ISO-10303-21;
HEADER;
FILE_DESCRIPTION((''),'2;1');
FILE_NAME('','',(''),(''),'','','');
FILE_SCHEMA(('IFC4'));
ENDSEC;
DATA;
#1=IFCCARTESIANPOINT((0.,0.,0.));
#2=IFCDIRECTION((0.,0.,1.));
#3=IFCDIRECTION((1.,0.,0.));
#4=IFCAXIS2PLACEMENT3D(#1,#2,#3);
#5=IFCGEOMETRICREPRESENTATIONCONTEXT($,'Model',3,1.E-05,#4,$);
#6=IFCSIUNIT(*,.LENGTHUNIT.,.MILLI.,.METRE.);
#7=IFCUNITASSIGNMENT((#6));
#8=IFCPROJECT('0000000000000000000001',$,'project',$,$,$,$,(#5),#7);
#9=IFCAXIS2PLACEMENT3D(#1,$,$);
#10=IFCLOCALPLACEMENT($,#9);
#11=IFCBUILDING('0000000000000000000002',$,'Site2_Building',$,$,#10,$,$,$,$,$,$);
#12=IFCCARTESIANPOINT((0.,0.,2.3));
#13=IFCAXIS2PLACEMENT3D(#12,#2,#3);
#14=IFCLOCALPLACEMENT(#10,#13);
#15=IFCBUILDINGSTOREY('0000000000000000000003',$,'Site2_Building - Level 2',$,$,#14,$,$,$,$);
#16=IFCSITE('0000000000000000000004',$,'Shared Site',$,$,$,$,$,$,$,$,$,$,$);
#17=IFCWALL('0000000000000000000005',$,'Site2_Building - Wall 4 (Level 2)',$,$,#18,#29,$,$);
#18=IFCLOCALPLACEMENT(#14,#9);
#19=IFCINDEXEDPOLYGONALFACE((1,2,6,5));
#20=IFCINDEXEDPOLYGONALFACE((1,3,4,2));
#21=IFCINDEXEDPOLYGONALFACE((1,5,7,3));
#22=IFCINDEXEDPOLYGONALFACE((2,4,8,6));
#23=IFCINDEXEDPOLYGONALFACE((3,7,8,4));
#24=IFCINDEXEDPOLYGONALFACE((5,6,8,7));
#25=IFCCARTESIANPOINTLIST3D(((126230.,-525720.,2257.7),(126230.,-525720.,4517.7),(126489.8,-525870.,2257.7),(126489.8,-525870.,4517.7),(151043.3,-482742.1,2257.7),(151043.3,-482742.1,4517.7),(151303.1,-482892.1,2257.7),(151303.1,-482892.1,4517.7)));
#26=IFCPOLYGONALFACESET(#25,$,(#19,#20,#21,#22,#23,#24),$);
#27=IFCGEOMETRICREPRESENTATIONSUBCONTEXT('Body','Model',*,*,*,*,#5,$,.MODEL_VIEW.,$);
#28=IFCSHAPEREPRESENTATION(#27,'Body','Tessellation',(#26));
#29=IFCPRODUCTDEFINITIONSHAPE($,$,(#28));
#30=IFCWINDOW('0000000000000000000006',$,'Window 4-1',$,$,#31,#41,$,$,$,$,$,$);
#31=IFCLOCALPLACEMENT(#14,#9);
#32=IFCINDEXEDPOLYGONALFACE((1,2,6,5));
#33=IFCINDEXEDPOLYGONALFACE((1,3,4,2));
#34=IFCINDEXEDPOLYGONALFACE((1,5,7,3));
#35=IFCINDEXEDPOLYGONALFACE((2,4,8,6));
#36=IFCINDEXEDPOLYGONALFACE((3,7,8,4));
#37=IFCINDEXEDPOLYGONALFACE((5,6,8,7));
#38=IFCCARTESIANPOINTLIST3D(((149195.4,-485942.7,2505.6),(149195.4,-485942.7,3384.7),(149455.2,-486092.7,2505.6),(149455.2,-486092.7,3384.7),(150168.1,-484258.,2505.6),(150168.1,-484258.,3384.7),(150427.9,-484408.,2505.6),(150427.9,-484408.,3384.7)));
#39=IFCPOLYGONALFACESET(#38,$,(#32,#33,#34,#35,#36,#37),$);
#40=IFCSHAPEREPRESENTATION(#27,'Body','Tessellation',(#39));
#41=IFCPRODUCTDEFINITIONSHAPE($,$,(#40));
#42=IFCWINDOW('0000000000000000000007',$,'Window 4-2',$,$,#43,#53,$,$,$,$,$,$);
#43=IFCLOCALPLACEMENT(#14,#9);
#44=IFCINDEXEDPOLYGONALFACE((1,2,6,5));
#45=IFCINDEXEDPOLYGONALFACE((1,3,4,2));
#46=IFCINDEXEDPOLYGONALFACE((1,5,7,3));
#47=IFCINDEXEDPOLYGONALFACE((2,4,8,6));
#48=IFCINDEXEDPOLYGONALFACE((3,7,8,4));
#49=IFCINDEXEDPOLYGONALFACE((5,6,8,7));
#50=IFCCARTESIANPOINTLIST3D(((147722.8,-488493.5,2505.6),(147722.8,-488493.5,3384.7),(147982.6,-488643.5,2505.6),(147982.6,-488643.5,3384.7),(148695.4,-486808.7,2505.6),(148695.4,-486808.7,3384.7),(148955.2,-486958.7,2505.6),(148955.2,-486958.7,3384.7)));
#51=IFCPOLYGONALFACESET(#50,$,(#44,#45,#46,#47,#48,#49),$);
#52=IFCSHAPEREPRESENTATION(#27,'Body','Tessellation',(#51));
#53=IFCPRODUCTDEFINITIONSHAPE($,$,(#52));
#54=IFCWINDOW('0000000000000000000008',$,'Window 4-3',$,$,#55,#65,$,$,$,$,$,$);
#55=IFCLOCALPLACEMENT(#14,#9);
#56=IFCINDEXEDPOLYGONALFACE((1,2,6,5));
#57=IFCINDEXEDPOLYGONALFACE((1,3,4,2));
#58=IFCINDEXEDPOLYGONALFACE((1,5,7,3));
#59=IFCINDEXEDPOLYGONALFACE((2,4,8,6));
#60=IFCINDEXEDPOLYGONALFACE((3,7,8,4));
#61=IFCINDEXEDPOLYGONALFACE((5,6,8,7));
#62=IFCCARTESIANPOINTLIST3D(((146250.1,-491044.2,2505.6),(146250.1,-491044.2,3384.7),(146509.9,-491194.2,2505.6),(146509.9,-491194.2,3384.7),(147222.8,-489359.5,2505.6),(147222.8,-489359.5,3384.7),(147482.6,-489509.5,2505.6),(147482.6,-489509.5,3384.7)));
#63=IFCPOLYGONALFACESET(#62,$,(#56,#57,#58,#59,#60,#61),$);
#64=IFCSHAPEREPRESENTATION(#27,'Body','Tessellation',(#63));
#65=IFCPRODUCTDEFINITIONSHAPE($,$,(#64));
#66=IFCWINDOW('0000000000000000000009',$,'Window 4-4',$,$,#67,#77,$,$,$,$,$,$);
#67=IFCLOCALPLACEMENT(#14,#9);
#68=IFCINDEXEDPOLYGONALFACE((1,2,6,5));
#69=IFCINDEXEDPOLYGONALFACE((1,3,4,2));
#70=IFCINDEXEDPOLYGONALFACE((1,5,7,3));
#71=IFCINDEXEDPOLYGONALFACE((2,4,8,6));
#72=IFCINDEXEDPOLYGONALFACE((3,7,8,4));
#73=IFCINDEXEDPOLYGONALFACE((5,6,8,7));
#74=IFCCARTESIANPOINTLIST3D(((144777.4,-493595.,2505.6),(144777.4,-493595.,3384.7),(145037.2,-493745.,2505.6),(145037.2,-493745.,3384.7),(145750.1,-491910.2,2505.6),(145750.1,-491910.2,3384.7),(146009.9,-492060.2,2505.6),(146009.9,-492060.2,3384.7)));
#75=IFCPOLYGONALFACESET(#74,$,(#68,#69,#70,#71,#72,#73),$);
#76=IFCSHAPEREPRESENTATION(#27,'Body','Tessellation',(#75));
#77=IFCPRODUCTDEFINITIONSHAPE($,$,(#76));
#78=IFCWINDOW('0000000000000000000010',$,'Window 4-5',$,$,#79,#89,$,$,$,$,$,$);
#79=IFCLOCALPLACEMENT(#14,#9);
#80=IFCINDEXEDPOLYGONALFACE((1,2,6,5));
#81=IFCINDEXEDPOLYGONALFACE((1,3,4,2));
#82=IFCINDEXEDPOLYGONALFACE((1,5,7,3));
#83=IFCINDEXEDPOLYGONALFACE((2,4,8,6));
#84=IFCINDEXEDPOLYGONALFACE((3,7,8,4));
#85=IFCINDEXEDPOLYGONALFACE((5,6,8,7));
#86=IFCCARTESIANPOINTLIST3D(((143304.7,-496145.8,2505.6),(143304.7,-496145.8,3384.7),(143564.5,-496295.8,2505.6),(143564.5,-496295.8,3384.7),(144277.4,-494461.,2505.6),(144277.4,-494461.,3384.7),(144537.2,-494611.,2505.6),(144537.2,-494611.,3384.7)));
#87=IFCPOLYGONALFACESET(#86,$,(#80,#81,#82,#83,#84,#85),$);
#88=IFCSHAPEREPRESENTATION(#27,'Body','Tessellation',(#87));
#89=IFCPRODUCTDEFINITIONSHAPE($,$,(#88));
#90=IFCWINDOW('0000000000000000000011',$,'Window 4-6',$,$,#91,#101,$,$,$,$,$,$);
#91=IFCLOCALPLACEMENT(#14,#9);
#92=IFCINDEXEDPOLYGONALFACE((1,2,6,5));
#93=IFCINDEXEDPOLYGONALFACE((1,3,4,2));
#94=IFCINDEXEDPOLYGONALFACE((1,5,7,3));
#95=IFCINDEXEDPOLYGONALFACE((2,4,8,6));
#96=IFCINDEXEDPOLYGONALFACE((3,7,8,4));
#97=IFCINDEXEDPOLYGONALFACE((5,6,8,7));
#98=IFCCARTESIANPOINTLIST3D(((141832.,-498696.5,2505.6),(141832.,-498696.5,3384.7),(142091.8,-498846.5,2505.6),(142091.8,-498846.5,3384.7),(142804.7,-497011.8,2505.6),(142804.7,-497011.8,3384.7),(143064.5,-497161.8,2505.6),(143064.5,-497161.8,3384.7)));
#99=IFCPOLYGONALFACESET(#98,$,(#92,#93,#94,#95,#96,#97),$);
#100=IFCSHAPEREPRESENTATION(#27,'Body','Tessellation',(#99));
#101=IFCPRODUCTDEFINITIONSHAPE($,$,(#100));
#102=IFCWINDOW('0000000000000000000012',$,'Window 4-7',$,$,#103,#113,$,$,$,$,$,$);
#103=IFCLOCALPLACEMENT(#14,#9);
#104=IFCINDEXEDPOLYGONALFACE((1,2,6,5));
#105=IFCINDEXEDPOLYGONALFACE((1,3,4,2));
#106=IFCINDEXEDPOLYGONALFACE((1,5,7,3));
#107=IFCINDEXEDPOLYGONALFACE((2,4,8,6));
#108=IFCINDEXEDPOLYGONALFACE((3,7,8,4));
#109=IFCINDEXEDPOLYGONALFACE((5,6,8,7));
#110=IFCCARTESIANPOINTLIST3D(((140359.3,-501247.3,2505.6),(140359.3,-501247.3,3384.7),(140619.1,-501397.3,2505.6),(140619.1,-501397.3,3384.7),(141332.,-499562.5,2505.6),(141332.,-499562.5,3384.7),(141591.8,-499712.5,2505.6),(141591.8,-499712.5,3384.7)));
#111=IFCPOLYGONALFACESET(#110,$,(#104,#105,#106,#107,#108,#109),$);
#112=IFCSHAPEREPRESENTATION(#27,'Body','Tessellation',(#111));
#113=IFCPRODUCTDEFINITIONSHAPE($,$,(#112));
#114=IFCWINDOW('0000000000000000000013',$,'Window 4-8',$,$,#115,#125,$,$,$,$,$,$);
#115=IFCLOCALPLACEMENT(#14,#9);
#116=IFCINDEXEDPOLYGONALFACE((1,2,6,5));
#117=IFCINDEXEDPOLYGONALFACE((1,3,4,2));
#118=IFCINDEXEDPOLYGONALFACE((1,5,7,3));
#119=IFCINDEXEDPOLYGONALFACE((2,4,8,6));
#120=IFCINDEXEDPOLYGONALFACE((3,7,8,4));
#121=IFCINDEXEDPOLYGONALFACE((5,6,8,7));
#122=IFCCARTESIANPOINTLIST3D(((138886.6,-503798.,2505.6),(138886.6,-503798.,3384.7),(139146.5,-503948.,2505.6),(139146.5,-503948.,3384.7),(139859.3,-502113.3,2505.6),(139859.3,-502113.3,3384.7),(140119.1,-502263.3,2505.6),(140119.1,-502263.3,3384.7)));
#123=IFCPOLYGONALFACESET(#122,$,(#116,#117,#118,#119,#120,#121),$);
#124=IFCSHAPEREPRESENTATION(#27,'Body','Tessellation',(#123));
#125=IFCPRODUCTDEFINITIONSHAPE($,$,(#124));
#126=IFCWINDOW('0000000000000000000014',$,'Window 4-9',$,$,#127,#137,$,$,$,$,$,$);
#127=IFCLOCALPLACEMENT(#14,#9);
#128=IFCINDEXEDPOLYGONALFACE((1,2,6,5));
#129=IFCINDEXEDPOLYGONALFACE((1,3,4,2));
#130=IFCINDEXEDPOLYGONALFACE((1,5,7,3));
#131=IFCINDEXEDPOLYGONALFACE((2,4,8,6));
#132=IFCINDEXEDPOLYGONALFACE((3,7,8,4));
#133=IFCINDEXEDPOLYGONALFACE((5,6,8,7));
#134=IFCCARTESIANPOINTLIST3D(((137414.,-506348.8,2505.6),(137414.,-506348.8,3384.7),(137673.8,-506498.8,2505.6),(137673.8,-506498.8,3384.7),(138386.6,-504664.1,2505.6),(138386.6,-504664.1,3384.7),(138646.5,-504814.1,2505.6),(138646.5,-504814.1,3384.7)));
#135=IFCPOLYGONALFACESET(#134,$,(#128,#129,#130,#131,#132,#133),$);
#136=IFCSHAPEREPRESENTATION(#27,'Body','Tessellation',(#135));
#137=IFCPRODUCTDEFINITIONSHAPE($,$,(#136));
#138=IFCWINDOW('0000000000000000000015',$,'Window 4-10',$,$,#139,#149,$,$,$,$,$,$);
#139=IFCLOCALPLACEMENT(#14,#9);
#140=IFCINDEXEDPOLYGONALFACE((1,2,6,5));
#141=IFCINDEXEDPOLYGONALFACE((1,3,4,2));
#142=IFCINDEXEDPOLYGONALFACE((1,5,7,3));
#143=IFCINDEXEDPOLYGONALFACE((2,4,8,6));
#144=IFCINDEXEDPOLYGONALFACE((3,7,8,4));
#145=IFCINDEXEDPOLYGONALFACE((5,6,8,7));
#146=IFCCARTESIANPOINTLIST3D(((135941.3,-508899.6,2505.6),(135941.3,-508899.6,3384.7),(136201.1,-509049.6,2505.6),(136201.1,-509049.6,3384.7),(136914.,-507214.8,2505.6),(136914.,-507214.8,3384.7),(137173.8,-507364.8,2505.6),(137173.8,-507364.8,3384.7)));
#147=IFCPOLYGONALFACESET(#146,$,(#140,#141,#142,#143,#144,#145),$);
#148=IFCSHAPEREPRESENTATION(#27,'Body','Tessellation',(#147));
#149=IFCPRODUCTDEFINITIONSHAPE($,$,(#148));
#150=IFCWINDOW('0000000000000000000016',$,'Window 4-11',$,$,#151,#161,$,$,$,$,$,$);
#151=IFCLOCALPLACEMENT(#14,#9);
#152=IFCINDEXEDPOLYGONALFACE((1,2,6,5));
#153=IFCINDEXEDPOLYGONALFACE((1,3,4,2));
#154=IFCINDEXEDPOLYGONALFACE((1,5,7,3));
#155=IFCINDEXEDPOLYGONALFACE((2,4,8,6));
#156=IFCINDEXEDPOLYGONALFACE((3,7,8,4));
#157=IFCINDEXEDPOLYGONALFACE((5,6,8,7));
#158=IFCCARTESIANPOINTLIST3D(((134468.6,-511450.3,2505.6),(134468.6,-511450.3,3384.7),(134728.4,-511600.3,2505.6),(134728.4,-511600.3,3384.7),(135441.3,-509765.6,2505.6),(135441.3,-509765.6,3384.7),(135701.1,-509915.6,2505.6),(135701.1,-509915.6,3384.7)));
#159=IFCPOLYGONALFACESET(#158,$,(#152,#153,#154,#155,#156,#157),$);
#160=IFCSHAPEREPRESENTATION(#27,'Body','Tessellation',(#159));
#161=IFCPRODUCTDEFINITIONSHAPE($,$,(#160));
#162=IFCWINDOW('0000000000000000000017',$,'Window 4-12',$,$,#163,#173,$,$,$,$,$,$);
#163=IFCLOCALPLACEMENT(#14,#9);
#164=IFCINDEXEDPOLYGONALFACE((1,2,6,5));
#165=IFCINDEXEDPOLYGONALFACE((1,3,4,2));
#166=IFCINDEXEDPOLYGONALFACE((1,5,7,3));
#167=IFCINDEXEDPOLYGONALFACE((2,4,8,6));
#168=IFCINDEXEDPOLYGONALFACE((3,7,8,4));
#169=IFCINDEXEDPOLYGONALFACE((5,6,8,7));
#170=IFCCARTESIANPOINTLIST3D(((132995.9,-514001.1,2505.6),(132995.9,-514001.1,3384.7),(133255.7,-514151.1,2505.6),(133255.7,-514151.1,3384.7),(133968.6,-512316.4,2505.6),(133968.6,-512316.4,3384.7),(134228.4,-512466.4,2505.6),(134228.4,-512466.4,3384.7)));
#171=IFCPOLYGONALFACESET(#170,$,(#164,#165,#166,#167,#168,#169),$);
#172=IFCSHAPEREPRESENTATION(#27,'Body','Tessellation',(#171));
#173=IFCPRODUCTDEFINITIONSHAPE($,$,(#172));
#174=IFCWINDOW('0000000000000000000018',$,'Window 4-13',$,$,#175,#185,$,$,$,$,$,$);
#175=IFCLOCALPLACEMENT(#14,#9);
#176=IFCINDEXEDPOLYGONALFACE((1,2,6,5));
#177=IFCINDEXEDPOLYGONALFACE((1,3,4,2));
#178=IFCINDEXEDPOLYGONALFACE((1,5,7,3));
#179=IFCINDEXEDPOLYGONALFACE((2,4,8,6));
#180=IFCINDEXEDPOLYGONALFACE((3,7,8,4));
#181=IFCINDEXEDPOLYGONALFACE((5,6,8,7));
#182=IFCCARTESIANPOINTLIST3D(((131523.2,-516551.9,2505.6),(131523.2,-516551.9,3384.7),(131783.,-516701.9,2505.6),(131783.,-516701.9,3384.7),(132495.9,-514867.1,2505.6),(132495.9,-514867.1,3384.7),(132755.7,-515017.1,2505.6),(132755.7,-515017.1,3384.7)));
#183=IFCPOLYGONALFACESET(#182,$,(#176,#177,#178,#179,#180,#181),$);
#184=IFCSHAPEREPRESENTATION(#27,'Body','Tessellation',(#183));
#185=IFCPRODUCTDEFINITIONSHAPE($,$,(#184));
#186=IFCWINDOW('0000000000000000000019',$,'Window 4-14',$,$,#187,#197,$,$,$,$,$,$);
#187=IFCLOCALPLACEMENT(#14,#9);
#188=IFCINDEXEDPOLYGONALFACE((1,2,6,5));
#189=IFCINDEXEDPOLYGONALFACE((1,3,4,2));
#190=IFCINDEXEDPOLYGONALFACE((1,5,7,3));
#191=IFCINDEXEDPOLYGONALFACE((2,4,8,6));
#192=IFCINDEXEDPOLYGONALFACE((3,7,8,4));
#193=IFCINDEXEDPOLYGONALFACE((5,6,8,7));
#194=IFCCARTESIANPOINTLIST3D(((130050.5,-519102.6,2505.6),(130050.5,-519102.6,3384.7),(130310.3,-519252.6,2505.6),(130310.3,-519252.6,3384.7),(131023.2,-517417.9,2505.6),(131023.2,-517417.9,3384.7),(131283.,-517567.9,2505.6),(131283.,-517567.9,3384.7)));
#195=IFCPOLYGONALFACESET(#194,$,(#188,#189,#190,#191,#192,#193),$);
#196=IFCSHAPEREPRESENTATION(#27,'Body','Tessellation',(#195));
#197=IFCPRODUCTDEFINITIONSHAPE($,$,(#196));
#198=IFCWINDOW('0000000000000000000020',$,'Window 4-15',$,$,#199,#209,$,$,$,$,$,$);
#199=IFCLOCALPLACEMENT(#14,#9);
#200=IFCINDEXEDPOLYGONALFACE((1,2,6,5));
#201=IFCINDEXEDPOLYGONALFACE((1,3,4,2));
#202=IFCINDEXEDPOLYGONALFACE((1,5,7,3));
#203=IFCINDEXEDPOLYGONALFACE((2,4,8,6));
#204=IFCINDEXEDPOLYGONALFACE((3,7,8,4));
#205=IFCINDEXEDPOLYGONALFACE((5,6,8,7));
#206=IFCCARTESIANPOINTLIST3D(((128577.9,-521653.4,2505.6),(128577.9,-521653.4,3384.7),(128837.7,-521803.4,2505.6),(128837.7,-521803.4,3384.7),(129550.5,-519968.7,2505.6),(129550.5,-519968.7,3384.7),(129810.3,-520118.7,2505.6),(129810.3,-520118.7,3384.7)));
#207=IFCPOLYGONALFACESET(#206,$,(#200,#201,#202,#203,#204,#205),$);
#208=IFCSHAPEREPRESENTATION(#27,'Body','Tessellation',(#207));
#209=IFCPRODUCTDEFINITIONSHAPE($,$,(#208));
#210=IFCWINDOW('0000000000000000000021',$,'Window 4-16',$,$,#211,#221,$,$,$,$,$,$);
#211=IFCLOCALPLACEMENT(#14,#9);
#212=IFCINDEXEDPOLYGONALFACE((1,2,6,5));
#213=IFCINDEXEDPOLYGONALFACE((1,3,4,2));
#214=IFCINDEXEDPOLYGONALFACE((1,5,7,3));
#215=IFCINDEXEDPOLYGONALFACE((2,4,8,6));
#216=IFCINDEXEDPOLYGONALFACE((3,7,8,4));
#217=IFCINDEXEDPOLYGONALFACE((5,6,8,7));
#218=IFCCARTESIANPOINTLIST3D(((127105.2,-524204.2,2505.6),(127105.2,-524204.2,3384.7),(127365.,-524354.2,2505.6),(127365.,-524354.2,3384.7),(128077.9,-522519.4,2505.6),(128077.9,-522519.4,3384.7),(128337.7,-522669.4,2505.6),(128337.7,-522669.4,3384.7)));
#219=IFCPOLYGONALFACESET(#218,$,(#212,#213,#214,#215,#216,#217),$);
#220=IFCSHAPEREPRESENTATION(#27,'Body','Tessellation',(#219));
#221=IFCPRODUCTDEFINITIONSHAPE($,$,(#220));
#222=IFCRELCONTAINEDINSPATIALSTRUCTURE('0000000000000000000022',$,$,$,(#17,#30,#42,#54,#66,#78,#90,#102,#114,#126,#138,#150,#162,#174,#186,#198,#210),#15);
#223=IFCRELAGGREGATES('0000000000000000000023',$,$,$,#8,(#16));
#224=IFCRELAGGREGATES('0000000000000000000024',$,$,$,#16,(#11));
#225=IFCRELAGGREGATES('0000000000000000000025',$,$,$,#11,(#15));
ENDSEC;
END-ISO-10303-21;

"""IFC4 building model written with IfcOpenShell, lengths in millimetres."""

from ifc_helpers import new_model, si_unit, frame, origin, origin_with_axes, place, context, subcontext, project, spatial, indexed_curve, outline, extrude, element, save


model = new_model("IFC4")

# Units and contexts
model_context = context("Model", 3, precision=1e-05, world=origin_with_axes())
body_context = subcontext(model_context, "Body", "Model", "MODEL_VIEW")
ifc_project = project(units=[si_unit("LENGTHUNIT", "METRE", prefix="MILLI")], contexts=[model_context])

# Site, building, storey
site = spatial("IfcSite", under=ifc_project, Name="Shared Site")
building_placement = place(None, origin())
building = spatial("IfcBuilding", under=site, at=building_placement, Name="Site2_Building")
storey_placement = place(building_placement, frame((0.0, 0.0, 2.3), z_axis=(0.0, 0.0, 1.0), x_axis=(1.0, 0.0, 0.0)))
storey = spatial("IfcBuildingStorey", under=building, at=storey_placement, Name="Site2_Building - Level 2")

# Wall
wall_1_placement = place(storey_placement, frame((151043.3, -482742.1, 2257.7), z_axis=(0.0, 0.0, 1.0), x_axis=(-0.5, -0.866025, 0.0)))
element("IfcWall", 1, at=wall_1_placement, inside=storey, Name="Site2_Building - Wall 4 (Level 2)", context=body_context, shape_type="SweptSolid", body=[
    extrude(outline(indexed_curve([(0.0, 0.0), (0.0, 300.0), (49626.6, 300.0), (49626.6, 0.0), (0.0, 0.0)], self_intersect=False)), origin_with_axes(), (0.0, 0.0, 1.0), 2260.0),
])

# Windows
for number, where, z_axis, x_axis, name in (
    (2, (150168.1, -484258.0, 2505.6), (0.0, 0.0, 1.0), (-0.5, -0.866025, 0.0), "Window 4-1"),
    (3, (148695.4, -486808.7, 2505.6), (0.0, 0.0, 1.0), (-0.5, -0.866025, 0.0), "Window 4-2"),
    (4, (147222.8, -489359.5, 2505.6), (0.0, 0.0, 1.0), (-0.5, -0.866025, 0.0), "Window 4-3"),
    (5, (145750.1, -491910.2, 2505.6), (0.0, 0.0, 1.0), (-0.5, -0.866025, 0.0), "Window 4-4"),
    (6, (144277.4, -494461.0, 2505.6), (0.0, 0.0, 1.0), (-0.5, -0.866025, 0.0), "Window 4-5"),
    (7, (142804.7, -497011.8, 2505.6), (0.0, 0.0, 1.0), (-0.5, -0.866025, 0.0), "Window 4-6"),
    (8, (141332.0, -499562.5, 2505.6), (0.0, 0.0, 1.0), (-0.5, -0.866025, 0.0), "Window 4-7"),
    (9, (139859.3, -502113.3, 2505.6), (0.0, 0.0, 1.0), (-0.5, -0.866025, 0.0), "Window 4-8"),
    (10, (138386.6, -504664.1, 2505.6), (0.0, 0.0, 1.0), (-0.5, -0.866025, 0.0), "Window 4-9"),
    (11, (136914.0, -507214.8, 2505.6), (0.0, 0.0, 1.0), (-0.5, -0.866025, 0.0), "Window 4-10"),
    (12, (135441.3, -509765.6, 2505.6), (0.0, 0.0, 1.0), (-0.5, -0.866025, 0.0), "Window 4-11"),
    (13, (133968.6, -512316.4, 2505.6), (0.0, 0.0, 1.0), (-0.5, -0.866025, 0.0), "Window 4-12"),
    (14, (132495.9, -514867.1, 2505.6), (0.0, 0.0, 1.0), (-0.5, -0.866025, 0.0), "Window 4-13"),
    (15, (131023.2, -517417.9, 2505.6), (0.0, 0.0, 1.0), (-0.5, -0.866025, 0.0), "Window 4-14"),
    (16, (129550.5, -519968.7, 2505.6), (0.0, 0.0, 1.0), (-0.5, -0.866025, 0.0), "Window 4-15"),
    (17, (128077.9, -522519.4, 2505.6), (0.0, 0.0, 1.0), (-0.5, -0.866025, 0.0), "Window 4-16"),
):
    element("IfcWindow", number, at=place(storey_placement, frame(where, z_axis=z_axis, x_axis=x_axis)), inside=storey, Name=name, context=body_context, shape_type="SweptSolid", body=[
        extrude(outline(indexed_curve([(0.0, 0.0), (0.0, 300.0), (1945.4, 300.0), (1945.4, 0.0), (0.0, 0.0)], self_intersect=False)), origin_with_axes(), (0.0, 0.0, 1.0), 879.1),
    ])

save(model, "model.ifc")
